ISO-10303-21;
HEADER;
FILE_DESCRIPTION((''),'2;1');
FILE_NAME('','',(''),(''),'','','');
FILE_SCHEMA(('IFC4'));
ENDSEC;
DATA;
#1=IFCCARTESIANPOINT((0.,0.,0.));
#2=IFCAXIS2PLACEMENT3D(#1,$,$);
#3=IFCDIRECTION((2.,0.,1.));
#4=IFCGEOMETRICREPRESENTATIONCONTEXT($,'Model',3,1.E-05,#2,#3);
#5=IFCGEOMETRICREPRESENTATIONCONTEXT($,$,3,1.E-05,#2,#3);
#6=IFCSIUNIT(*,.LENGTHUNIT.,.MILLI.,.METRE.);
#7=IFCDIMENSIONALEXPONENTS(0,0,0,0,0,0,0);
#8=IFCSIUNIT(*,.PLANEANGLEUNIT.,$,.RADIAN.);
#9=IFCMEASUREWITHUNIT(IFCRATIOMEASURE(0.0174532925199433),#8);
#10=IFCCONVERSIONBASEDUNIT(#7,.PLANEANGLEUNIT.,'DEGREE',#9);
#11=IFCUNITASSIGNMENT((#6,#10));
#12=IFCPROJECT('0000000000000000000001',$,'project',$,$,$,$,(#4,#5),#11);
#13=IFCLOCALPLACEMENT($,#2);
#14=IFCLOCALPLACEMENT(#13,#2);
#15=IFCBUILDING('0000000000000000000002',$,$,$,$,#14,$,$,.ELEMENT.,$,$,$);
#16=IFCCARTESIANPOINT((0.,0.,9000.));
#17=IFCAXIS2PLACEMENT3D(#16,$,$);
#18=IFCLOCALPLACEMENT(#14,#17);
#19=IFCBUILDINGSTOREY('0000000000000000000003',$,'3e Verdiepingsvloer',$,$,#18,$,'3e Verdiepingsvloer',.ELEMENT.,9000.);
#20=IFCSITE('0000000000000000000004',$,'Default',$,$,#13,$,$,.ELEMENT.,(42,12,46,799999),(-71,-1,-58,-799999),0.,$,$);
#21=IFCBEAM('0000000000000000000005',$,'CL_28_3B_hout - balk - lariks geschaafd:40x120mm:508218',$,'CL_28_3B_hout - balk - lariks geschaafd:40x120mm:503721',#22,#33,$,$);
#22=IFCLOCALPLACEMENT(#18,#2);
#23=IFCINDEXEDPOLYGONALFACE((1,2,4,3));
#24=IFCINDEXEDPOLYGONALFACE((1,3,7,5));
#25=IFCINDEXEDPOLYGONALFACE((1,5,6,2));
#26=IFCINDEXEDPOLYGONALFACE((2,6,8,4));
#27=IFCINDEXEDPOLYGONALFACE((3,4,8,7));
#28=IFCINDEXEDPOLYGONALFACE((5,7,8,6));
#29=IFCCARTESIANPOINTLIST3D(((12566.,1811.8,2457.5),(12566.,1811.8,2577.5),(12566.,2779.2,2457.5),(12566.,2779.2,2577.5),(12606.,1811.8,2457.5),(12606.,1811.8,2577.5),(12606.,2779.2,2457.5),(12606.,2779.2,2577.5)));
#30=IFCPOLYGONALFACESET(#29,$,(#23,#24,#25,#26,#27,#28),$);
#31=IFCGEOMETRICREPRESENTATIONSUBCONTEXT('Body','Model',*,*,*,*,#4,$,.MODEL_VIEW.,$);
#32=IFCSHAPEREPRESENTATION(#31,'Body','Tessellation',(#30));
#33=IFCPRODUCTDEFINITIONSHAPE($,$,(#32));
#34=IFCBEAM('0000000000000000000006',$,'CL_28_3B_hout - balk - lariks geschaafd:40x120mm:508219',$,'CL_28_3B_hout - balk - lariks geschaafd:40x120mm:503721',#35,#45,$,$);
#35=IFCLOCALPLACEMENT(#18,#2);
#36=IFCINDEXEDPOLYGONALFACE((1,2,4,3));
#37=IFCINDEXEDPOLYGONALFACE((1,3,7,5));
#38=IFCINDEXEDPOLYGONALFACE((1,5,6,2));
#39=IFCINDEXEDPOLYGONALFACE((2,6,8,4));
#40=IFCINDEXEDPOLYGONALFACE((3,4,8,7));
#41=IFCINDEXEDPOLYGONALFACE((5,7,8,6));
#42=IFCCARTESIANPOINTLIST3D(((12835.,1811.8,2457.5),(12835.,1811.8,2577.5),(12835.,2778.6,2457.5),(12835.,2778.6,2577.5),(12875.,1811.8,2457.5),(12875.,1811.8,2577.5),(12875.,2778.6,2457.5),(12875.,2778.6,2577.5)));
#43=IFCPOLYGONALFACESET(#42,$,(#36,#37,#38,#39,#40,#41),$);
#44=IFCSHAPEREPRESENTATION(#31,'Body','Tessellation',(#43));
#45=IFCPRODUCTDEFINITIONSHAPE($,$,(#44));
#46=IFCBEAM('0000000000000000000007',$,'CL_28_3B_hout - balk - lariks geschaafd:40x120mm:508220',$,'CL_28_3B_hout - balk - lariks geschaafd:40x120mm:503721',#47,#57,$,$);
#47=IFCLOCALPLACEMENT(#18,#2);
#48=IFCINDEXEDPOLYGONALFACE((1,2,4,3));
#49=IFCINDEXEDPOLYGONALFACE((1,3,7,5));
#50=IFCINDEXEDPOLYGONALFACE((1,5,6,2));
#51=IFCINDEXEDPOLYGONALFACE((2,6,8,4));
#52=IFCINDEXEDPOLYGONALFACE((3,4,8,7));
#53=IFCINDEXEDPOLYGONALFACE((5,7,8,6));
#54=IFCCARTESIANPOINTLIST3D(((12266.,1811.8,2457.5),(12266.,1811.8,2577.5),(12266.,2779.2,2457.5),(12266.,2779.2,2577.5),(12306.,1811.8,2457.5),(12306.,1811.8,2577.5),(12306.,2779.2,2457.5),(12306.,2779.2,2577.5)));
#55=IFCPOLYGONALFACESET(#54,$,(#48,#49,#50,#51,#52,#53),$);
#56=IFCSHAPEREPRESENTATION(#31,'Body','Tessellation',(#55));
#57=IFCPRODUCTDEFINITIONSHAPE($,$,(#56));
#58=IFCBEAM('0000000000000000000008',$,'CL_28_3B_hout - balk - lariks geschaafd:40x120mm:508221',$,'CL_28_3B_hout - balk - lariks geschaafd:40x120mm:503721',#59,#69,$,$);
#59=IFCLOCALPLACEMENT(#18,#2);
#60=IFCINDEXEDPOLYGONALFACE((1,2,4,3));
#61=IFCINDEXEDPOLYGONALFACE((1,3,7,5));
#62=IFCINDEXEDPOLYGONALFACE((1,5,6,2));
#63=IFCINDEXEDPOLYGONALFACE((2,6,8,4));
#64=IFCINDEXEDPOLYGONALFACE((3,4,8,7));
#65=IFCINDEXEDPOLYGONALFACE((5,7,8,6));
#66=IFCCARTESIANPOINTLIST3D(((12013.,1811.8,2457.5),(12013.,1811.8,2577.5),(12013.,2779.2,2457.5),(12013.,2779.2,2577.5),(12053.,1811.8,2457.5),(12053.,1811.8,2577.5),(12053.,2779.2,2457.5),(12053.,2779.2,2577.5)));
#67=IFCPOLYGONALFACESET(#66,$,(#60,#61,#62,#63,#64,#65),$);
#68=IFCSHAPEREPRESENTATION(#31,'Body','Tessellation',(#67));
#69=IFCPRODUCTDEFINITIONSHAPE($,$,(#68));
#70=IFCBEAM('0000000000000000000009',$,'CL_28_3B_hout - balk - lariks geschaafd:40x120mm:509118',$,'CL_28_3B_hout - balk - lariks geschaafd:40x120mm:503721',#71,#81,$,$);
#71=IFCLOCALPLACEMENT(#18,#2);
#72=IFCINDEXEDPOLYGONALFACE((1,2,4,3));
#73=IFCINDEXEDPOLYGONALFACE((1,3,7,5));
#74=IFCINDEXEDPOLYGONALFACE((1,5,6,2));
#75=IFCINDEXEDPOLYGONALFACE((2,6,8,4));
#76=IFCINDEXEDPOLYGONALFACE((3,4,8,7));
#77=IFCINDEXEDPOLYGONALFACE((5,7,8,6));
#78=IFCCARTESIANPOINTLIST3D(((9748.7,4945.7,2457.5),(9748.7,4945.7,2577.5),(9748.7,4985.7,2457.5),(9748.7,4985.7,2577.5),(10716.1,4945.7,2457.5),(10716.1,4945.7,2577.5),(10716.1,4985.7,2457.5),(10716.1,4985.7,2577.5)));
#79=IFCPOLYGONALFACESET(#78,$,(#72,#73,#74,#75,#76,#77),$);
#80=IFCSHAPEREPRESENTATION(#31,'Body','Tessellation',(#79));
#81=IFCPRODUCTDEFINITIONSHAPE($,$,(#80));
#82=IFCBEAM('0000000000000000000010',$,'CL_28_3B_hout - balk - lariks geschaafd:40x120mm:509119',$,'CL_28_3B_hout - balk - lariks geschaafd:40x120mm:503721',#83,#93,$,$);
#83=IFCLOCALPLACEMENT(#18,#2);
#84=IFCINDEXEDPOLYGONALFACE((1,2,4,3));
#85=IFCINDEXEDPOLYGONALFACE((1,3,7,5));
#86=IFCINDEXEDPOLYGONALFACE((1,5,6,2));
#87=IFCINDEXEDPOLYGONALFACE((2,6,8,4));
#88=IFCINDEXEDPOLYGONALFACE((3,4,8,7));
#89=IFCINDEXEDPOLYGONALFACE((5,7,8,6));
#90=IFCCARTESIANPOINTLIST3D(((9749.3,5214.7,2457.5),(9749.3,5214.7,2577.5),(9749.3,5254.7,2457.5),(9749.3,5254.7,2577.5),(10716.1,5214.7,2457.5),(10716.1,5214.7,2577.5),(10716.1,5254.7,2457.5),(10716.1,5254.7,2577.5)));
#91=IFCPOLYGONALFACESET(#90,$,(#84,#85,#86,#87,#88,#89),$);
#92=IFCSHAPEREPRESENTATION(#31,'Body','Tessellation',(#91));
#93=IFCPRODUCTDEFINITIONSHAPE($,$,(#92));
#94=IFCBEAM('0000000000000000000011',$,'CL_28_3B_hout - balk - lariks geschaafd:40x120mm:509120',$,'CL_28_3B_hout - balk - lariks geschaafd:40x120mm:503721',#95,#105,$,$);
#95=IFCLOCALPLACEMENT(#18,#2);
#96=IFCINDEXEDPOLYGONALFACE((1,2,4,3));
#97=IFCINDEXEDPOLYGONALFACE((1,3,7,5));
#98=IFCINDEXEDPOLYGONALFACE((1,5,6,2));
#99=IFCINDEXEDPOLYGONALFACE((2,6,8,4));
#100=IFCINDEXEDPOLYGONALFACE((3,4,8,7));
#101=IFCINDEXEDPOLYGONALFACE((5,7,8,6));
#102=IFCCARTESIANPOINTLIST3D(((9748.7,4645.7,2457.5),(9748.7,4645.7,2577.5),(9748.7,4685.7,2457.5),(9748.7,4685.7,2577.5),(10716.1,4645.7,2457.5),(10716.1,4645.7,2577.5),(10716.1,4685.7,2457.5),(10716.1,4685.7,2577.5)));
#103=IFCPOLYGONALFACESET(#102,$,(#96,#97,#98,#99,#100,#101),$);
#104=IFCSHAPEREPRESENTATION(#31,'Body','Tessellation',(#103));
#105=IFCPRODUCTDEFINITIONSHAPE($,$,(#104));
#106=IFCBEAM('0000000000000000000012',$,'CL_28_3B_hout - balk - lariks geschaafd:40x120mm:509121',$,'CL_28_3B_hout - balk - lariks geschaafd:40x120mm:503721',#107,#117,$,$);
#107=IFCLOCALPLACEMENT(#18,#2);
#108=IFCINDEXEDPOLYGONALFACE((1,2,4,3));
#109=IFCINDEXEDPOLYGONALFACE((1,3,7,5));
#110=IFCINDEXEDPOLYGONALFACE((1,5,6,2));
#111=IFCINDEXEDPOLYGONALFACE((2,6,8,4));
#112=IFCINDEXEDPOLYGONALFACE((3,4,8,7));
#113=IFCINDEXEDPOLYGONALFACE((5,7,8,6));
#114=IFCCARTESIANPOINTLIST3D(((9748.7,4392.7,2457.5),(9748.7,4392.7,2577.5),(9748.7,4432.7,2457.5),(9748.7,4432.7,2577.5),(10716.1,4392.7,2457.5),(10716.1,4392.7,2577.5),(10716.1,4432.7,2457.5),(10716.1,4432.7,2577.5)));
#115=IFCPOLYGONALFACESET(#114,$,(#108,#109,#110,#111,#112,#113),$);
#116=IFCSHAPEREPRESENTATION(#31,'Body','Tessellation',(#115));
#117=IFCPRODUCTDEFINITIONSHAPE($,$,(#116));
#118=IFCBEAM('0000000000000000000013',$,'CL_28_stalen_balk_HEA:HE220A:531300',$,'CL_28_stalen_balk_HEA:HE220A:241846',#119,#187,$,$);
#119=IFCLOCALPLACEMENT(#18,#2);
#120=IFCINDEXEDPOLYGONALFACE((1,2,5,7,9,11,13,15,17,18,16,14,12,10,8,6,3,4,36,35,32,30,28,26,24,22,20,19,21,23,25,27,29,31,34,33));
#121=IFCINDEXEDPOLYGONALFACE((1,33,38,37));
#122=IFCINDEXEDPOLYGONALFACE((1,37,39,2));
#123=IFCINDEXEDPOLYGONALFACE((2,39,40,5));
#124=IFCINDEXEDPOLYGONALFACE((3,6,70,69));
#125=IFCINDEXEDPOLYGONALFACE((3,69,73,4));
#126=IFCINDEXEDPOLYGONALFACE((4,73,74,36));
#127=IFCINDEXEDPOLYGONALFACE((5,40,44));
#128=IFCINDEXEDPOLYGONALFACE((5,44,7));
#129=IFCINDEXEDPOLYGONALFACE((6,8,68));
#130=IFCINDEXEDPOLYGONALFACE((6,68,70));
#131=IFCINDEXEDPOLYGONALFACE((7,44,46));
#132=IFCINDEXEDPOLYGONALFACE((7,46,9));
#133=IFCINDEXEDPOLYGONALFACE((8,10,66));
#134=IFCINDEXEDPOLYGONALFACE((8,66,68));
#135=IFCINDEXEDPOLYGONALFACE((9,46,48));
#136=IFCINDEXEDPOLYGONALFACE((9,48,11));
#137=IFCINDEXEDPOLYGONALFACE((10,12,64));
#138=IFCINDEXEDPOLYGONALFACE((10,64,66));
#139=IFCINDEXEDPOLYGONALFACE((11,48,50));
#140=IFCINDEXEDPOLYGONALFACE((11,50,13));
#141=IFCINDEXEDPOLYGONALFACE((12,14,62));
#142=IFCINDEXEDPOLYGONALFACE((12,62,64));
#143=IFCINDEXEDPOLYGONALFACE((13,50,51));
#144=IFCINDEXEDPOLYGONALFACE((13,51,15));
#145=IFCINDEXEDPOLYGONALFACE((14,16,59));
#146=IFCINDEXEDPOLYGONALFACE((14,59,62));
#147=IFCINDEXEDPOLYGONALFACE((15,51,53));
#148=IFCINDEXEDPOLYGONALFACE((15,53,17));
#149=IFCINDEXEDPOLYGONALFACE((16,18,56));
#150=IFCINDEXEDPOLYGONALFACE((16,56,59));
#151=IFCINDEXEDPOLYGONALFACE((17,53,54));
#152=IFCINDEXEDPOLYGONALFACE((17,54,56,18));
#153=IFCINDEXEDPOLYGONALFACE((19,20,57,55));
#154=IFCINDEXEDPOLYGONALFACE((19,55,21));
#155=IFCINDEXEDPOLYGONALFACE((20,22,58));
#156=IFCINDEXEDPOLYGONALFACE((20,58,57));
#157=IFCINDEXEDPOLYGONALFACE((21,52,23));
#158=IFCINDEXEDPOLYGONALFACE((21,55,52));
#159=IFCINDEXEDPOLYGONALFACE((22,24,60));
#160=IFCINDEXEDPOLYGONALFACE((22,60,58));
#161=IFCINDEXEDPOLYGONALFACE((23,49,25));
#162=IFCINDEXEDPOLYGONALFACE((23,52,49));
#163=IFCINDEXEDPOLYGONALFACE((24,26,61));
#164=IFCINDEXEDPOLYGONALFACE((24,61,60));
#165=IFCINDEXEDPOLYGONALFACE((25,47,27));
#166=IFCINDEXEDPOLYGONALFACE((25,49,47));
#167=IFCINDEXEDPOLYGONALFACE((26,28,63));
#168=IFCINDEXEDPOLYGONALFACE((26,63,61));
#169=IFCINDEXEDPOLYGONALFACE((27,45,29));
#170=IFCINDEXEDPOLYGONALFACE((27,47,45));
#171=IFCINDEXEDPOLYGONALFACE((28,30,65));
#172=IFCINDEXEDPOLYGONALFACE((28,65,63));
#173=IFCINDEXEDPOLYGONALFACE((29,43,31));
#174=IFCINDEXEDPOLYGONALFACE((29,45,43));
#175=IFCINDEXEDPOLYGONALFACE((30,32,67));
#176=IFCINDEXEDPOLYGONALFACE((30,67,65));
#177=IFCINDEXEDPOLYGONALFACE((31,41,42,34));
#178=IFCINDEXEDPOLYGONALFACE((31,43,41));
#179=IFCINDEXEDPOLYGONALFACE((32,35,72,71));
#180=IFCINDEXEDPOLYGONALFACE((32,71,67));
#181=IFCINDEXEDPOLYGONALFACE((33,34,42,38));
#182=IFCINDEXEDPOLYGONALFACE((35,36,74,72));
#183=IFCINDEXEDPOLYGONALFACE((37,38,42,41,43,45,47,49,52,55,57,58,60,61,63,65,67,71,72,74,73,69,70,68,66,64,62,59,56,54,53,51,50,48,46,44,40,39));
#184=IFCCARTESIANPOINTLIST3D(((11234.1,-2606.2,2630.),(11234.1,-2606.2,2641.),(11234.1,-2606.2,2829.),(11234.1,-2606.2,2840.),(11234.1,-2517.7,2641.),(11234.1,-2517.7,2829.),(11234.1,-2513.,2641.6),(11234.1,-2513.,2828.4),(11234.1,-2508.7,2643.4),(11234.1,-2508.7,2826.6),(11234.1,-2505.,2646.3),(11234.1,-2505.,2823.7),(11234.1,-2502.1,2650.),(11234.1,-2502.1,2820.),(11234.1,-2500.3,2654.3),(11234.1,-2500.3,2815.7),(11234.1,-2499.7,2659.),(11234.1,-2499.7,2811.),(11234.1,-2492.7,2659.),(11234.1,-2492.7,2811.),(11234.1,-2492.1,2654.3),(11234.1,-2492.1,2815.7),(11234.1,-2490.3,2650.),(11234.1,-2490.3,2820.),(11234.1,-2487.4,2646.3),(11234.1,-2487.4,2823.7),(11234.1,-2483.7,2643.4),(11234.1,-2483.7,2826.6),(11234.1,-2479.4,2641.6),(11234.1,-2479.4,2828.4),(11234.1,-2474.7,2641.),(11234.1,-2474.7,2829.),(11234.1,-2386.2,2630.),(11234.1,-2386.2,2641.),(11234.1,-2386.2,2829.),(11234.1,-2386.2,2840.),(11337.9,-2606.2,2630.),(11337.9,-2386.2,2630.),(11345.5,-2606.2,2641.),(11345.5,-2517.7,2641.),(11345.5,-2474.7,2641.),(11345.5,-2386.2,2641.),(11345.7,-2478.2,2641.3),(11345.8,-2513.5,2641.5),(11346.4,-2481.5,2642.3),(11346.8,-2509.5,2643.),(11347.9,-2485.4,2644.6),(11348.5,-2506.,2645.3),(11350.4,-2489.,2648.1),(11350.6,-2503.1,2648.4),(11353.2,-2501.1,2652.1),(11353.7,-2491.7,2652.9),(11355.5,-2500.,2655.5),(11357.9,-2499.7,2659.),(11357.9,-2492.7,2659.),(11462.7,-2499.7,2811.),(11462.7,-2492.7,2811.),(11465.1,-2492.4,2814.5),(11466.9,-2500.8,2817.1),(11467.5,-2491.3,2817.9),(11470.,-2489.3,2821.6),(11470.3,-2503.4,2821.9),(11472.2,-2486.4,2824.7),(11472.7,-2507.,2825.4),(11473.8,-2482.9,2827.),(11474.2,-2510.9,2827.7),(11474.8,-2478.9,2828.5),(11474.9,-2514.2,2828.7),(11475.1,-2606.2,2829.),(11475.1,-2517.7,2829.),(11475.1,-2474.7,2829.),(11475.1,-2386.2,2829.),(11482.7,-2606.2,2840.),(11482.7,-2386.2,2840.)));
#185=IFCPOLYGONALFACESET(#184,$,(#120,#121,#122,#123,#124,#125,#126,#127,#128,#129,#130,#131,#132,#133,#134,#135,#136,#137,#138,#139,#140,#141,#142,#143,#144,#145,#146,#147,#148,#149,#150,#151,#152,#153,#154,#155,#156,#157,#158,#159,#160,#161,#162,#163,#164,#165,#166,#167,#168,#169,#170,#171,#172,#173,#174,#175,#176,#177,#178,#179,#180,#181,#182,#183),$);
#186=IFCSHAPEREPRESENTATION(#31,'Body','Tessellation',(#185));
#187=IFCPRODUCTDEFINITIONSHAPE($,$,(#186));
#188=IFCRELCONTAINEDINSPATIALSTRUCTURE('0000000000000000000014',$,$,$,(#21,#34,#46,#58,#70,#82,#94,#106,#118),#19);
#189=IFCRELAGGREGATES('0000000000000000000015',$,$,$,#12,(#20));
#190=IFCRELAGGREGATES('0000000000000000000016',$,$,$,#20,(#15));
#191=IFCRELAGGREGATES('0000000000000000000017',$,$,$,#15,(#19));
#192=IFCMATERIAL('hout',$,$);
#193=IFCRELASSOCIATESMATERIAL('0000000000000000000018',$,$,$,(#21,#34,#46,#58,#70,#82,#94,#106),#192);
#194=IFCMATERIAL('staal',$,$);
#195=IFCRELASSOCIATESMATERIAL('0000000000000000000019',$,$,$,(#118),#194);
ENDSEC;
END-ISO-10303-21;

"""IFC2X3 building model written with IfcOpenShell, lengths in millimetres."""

from ifc_helpers import new_model, entity, si_unit, converted_unit, direction, frame, frame_2d, origin, origin_2d_with_axis, place, context, subcontext, project, spatial, rectangle, i_section, extrude, clip, halfspace, material, element, save


model = new_model("IFC2X3")

# Units and contexts
model_context = context("Model", 3, precision=1e-05, world=origin(), true_north=direction((2.0, 0.0, 1.0)))
context_of_model = context(None, 3, precision=1e-05, world=origin(), true_north=direction((2.0, 0.0, 1.0)))
body_context = subcontext(model_context, "Body", "Model", "MODEL_VIEW")
ifc_project = project(units=[si_unit("LENGTHUNIT", "METRE", prefix="MILLI"), converted_unit("PLANEANGLEUNIT", "DEGREE", entity("IfcRatioMeasure", 0.0174532925199433), si_unit("PLANEANGLEUNIT", "RADIAN"), dimensions=[0, 0, 0, 0, 0, 0, 0])], contexts=[model_context, context_of_model])

# Site, building, storey
site_placement = place(None, origin())
site = spatial("IfcSite", under=ifc_project, at=site_placement, Name="Default", CompositionType="ELEMENT", RefLatitude=(42, 12, 46, 799999), RefLongitude=(-71, -1, -58, -799999), RefElevation=0.0)
building_placement = place(site_placement, origin())
building = spatial("IfcBuilding", under=site, at=building_placement, CompositionType="ELEMENT")
storey_placement = place(building_placement, frame((0.0, 0.0, 9000.0)))
storey = spatial("IfcBuildingStorey", under=building, at=storey_placement, Name="3e Verdiepingsvloer", LongName="3e Verdiepingsvloer", CompositionType="ELEMENT", Elevation=9000.0)

# Beams
ifc_material_1 = material(Name="staal")
ifc_material_2 = material(Name="hout")
beam_1_placement = place(storey_placement, frame((12586.0, 2847.8, 2577.5), z_axis=(0.0, 0.0, 1.0), x_axis=(0.0, -1.0, 0.0)))
element("IfcBeam", 1, at=beam_1_placement, inside=storey, material=ifc_material_2, Name="CL_28_3B_hout - balk - lariks geschaafd:40x120mm:508218", ObjectType="CL_28_3B_hout - balk - lariks geschaafd:40x120mm:503721", context=body_context, shape_type="SweptSolid", body=[
    extrude(rectangle(XDim=120.0, YDim=40.0, at=origin_2d_with_axis()), frame((68.6, 0.0, -60.0), z_axis=(1.0, 0.0, 0.0), x_axis=(0.0, 0.0, -1.0)), (0.0, 0.0, 1.0), 967.4),
])
beam_2_placement = place(storey_placement, frame((12855.0, 2887.8, 2577.5), z_axis=(0.0, 0.0, 1.0), x_axis=(0.0, -1.0, 0.0)))
element("IfcBeam", 2, at=beam_2_placement, inside=storey, material=ifc_material_2, Name="CL_28_3B_hout - balk - lariks geschaafd:40x120mm:508219", ObjectType="CL_28_3B_hout - balk - lariks geschaafd:40x120mm:503721", context=body_context, shape_type="SweptSolid", body=[
    extrude(rectangle(XDim=120.0, YDim=40.0, at=origin_2d_with_axis()), frame((109.2, 0.0, -60.0), z_axis=(1.0, 0.0, 0.0), x_axis=(0.0, 0.0, -1.0)), (0.0, 0.0, 1.0), 966.8),
])
beam_3_placement = place(storey_placement, frame((12286.0, 2852.8, 2577.5), z_axis=(0.0, 0.0, 1.0), x_axis=(0.0, -1.0, 0.0)))
element("IfcBeam", 3, at=beam_3_placement, inside=storey, material=ifc_material_2, Name="CL_28_3B_hout - balk - lariks geschaafd:40x120mm:508220", ObjectType="CL_28_3B_hout - balk - lariks geschaafd:40x120mm:503721", context=body_context, shape_type="SweptSolid", body=[
    extrude(rectangle(XDim=120.0, YDim=40.0, at=origin_2d_with_axis()), frame((73.6, 0.0, -60.0), z_axis=(1.0, 0.0, 0.0), x_axis=(0.0, 0.0, -1.0)), (0.0, 0.0, 1.0), 967.4),
])
beam_4_placement = place(storey_placement, frame((12033.0, 2847.8, 2577.5), z_axis=(0.0, 0.0, 1.0), x_axis=(0.0, -1.0, 0.0)))
element("IfcBeam", 4, at=beam_4_placement, inside=storey, material=ifc_material_2, Name="CL_28_3B_hout - balk - lariks geschaafd:40x120mm:508221", ObjectType="CL_28_3B_hout - balk - lariks geschaafd:40x120mm:503721", context=body_context, shape_type="SweptSolid", body=[
    extrude(rectangle(XDim=120.0, YDim=40.0, at=origin_2d_with_axis()), frame((68.6, 0.0, -60.0), z_axis=(1.0, 0.0, 0.0), x_axis=(0.0, 0.0, -1.0)), (0.0, 0.0, 1.0), 967.4),
])
beam_5_placement = place(storey_placement, frame((9680.1, 4965.7, 2577.5)))
element("IfcBeam", 5, at=beam_5_placement, inside=storey, material=ifc_material_2, Name="CL_28_3B_hout - balk - lariks geschaafd:40x120mm:509118", ObjectType="CL_28_3B_hout - balk - lariks geschaafd:40x120mm:503721", context=body_context, shape_type="SweptSolid", body=[
    extrude(rectangle(XDim=120.0, YDim=40.0, at=origin_2d_with_axis()), frame((68.6, 0.0, -60.0), z_axis=(1.0, 0.0, 0.0), x_axis=(0.0, 0.0, -1.0)), (0.0, 0.0, 1.0), 967.4),
])
beam_6_placement = place(storey_placement, frame((9640.1, 5234.7, 2577.5)))
element("IfcBeam", 6, at=beam_6_placement, inside=storey, material=ifc_material_2, Name="CL_28_3B_hout - balk - lariks geschaafd:40x120mm:509119", ObjectType="CL_28_3B_hout - balk - lariks geschaafd:40x120mm:503721", context=body_context, shape_type="SweptSolid", body=[
    extrude(rectangle(XDim=120.0, YDim=40.0, at=origin_2d_with_axis()), frame((109.2, 0.0, -60.0), z_axis=(1.0, 0.0, 0.0), x_axis=(0.0, 0.0, -1.0)), (0.0, 0.0, 1.0), 966.8),
])
beam_7_placement = place(storey_placement, frame((9675.1, 4665.7, 2577.5)))
element("IfcBeam", 7, at=beam_7_placement, inside=storey, material=ifc_material_2, Name="CL_28_3B_hout - balk - lariks geschaafd:40x120mm:509120", ObjectType="CL_28_3B_hout - balk - lariks geschaafd:40x120mm:503721", context=body_context, shape_type="SweptSolid", body=[
    extrude(rectangle(XDim=120.0, YDim=40.0, at=frame_2d((0.0, 0.0), x_axis=(1.0, 0.0))), frame((73.6, 0.0, -60.0), z_axis=(1.0, 0.0, 0.0), x_axis=(0.0, 0.0, -1.0)), (0.0, 0.0, 1.0), 967.4),
])
beam_8_placement = place(storey_placement, frame((9680.1, 4412.7, 2577.5)))
element("IfcBeam", 8, at=beam_8_placement, inside=storey, material=ifc_material_2, Name="CL_28_3B_hout - balk - lariks geschaafd:40x120mm:509121", ObjectType="CL_28_3B_hout - balk - lariks geschaafd:40x120mm:503721", context=body_context, shape_type="SweptSolid", body=[
    extrude(rectangle(XDim=120.0, YDim=40.0, at=frame_2d((0.0, 0.0), x_axis=(1.0, 0.0))), frame((68.6, 0.0, -60.0), z_axis=(1.0, 0.0, 0.0), x_axis=(0.0, 0.0, -1.0)), (0.0, 0.0, 1.0), 967.4),
])
beam_9_placement = place(storey_placement, frame((11964.1, -2496.2, 2840.0), z_axis=(0.0, 0.0, 1.0), x_axis=(-1.0, 0.0, 0.0)))
element("IfcBeam", 9, at=beam_9_placement, inside=storey, material=ifc_material_1, Name="CL_28_stalen_balk_HEA:HE220A:531300", ObjectType="CL_28_stalen_balk_HEA:HE220A:241846", context=body_context, shape_type="Clipping", body=[
    clip(extrude(i_section(OverallWidth=220.0, OverallDepth=210.0, WebThickness=7.0, FlangeThickness=11.0, FilletRadius=18.0, at=frame_2d((0.0, 0.0), x_axis=(0.0, 1.0))), frame((481.4, 0.0, -105.0), z_axis=(1.0, 0.0, 0.0), x_axis=(0.0, 0.0, -1.0)), (0.0, 0.0, 1.0), 248.7), halfspace(frame((474.5, -667.6, 10.0), z_axis=(-0.823229, 0.0, -0.567709), x_axis=(-0.567709, 0.0, 0.823229)), False)),
])

save(model, "model.ifc")
